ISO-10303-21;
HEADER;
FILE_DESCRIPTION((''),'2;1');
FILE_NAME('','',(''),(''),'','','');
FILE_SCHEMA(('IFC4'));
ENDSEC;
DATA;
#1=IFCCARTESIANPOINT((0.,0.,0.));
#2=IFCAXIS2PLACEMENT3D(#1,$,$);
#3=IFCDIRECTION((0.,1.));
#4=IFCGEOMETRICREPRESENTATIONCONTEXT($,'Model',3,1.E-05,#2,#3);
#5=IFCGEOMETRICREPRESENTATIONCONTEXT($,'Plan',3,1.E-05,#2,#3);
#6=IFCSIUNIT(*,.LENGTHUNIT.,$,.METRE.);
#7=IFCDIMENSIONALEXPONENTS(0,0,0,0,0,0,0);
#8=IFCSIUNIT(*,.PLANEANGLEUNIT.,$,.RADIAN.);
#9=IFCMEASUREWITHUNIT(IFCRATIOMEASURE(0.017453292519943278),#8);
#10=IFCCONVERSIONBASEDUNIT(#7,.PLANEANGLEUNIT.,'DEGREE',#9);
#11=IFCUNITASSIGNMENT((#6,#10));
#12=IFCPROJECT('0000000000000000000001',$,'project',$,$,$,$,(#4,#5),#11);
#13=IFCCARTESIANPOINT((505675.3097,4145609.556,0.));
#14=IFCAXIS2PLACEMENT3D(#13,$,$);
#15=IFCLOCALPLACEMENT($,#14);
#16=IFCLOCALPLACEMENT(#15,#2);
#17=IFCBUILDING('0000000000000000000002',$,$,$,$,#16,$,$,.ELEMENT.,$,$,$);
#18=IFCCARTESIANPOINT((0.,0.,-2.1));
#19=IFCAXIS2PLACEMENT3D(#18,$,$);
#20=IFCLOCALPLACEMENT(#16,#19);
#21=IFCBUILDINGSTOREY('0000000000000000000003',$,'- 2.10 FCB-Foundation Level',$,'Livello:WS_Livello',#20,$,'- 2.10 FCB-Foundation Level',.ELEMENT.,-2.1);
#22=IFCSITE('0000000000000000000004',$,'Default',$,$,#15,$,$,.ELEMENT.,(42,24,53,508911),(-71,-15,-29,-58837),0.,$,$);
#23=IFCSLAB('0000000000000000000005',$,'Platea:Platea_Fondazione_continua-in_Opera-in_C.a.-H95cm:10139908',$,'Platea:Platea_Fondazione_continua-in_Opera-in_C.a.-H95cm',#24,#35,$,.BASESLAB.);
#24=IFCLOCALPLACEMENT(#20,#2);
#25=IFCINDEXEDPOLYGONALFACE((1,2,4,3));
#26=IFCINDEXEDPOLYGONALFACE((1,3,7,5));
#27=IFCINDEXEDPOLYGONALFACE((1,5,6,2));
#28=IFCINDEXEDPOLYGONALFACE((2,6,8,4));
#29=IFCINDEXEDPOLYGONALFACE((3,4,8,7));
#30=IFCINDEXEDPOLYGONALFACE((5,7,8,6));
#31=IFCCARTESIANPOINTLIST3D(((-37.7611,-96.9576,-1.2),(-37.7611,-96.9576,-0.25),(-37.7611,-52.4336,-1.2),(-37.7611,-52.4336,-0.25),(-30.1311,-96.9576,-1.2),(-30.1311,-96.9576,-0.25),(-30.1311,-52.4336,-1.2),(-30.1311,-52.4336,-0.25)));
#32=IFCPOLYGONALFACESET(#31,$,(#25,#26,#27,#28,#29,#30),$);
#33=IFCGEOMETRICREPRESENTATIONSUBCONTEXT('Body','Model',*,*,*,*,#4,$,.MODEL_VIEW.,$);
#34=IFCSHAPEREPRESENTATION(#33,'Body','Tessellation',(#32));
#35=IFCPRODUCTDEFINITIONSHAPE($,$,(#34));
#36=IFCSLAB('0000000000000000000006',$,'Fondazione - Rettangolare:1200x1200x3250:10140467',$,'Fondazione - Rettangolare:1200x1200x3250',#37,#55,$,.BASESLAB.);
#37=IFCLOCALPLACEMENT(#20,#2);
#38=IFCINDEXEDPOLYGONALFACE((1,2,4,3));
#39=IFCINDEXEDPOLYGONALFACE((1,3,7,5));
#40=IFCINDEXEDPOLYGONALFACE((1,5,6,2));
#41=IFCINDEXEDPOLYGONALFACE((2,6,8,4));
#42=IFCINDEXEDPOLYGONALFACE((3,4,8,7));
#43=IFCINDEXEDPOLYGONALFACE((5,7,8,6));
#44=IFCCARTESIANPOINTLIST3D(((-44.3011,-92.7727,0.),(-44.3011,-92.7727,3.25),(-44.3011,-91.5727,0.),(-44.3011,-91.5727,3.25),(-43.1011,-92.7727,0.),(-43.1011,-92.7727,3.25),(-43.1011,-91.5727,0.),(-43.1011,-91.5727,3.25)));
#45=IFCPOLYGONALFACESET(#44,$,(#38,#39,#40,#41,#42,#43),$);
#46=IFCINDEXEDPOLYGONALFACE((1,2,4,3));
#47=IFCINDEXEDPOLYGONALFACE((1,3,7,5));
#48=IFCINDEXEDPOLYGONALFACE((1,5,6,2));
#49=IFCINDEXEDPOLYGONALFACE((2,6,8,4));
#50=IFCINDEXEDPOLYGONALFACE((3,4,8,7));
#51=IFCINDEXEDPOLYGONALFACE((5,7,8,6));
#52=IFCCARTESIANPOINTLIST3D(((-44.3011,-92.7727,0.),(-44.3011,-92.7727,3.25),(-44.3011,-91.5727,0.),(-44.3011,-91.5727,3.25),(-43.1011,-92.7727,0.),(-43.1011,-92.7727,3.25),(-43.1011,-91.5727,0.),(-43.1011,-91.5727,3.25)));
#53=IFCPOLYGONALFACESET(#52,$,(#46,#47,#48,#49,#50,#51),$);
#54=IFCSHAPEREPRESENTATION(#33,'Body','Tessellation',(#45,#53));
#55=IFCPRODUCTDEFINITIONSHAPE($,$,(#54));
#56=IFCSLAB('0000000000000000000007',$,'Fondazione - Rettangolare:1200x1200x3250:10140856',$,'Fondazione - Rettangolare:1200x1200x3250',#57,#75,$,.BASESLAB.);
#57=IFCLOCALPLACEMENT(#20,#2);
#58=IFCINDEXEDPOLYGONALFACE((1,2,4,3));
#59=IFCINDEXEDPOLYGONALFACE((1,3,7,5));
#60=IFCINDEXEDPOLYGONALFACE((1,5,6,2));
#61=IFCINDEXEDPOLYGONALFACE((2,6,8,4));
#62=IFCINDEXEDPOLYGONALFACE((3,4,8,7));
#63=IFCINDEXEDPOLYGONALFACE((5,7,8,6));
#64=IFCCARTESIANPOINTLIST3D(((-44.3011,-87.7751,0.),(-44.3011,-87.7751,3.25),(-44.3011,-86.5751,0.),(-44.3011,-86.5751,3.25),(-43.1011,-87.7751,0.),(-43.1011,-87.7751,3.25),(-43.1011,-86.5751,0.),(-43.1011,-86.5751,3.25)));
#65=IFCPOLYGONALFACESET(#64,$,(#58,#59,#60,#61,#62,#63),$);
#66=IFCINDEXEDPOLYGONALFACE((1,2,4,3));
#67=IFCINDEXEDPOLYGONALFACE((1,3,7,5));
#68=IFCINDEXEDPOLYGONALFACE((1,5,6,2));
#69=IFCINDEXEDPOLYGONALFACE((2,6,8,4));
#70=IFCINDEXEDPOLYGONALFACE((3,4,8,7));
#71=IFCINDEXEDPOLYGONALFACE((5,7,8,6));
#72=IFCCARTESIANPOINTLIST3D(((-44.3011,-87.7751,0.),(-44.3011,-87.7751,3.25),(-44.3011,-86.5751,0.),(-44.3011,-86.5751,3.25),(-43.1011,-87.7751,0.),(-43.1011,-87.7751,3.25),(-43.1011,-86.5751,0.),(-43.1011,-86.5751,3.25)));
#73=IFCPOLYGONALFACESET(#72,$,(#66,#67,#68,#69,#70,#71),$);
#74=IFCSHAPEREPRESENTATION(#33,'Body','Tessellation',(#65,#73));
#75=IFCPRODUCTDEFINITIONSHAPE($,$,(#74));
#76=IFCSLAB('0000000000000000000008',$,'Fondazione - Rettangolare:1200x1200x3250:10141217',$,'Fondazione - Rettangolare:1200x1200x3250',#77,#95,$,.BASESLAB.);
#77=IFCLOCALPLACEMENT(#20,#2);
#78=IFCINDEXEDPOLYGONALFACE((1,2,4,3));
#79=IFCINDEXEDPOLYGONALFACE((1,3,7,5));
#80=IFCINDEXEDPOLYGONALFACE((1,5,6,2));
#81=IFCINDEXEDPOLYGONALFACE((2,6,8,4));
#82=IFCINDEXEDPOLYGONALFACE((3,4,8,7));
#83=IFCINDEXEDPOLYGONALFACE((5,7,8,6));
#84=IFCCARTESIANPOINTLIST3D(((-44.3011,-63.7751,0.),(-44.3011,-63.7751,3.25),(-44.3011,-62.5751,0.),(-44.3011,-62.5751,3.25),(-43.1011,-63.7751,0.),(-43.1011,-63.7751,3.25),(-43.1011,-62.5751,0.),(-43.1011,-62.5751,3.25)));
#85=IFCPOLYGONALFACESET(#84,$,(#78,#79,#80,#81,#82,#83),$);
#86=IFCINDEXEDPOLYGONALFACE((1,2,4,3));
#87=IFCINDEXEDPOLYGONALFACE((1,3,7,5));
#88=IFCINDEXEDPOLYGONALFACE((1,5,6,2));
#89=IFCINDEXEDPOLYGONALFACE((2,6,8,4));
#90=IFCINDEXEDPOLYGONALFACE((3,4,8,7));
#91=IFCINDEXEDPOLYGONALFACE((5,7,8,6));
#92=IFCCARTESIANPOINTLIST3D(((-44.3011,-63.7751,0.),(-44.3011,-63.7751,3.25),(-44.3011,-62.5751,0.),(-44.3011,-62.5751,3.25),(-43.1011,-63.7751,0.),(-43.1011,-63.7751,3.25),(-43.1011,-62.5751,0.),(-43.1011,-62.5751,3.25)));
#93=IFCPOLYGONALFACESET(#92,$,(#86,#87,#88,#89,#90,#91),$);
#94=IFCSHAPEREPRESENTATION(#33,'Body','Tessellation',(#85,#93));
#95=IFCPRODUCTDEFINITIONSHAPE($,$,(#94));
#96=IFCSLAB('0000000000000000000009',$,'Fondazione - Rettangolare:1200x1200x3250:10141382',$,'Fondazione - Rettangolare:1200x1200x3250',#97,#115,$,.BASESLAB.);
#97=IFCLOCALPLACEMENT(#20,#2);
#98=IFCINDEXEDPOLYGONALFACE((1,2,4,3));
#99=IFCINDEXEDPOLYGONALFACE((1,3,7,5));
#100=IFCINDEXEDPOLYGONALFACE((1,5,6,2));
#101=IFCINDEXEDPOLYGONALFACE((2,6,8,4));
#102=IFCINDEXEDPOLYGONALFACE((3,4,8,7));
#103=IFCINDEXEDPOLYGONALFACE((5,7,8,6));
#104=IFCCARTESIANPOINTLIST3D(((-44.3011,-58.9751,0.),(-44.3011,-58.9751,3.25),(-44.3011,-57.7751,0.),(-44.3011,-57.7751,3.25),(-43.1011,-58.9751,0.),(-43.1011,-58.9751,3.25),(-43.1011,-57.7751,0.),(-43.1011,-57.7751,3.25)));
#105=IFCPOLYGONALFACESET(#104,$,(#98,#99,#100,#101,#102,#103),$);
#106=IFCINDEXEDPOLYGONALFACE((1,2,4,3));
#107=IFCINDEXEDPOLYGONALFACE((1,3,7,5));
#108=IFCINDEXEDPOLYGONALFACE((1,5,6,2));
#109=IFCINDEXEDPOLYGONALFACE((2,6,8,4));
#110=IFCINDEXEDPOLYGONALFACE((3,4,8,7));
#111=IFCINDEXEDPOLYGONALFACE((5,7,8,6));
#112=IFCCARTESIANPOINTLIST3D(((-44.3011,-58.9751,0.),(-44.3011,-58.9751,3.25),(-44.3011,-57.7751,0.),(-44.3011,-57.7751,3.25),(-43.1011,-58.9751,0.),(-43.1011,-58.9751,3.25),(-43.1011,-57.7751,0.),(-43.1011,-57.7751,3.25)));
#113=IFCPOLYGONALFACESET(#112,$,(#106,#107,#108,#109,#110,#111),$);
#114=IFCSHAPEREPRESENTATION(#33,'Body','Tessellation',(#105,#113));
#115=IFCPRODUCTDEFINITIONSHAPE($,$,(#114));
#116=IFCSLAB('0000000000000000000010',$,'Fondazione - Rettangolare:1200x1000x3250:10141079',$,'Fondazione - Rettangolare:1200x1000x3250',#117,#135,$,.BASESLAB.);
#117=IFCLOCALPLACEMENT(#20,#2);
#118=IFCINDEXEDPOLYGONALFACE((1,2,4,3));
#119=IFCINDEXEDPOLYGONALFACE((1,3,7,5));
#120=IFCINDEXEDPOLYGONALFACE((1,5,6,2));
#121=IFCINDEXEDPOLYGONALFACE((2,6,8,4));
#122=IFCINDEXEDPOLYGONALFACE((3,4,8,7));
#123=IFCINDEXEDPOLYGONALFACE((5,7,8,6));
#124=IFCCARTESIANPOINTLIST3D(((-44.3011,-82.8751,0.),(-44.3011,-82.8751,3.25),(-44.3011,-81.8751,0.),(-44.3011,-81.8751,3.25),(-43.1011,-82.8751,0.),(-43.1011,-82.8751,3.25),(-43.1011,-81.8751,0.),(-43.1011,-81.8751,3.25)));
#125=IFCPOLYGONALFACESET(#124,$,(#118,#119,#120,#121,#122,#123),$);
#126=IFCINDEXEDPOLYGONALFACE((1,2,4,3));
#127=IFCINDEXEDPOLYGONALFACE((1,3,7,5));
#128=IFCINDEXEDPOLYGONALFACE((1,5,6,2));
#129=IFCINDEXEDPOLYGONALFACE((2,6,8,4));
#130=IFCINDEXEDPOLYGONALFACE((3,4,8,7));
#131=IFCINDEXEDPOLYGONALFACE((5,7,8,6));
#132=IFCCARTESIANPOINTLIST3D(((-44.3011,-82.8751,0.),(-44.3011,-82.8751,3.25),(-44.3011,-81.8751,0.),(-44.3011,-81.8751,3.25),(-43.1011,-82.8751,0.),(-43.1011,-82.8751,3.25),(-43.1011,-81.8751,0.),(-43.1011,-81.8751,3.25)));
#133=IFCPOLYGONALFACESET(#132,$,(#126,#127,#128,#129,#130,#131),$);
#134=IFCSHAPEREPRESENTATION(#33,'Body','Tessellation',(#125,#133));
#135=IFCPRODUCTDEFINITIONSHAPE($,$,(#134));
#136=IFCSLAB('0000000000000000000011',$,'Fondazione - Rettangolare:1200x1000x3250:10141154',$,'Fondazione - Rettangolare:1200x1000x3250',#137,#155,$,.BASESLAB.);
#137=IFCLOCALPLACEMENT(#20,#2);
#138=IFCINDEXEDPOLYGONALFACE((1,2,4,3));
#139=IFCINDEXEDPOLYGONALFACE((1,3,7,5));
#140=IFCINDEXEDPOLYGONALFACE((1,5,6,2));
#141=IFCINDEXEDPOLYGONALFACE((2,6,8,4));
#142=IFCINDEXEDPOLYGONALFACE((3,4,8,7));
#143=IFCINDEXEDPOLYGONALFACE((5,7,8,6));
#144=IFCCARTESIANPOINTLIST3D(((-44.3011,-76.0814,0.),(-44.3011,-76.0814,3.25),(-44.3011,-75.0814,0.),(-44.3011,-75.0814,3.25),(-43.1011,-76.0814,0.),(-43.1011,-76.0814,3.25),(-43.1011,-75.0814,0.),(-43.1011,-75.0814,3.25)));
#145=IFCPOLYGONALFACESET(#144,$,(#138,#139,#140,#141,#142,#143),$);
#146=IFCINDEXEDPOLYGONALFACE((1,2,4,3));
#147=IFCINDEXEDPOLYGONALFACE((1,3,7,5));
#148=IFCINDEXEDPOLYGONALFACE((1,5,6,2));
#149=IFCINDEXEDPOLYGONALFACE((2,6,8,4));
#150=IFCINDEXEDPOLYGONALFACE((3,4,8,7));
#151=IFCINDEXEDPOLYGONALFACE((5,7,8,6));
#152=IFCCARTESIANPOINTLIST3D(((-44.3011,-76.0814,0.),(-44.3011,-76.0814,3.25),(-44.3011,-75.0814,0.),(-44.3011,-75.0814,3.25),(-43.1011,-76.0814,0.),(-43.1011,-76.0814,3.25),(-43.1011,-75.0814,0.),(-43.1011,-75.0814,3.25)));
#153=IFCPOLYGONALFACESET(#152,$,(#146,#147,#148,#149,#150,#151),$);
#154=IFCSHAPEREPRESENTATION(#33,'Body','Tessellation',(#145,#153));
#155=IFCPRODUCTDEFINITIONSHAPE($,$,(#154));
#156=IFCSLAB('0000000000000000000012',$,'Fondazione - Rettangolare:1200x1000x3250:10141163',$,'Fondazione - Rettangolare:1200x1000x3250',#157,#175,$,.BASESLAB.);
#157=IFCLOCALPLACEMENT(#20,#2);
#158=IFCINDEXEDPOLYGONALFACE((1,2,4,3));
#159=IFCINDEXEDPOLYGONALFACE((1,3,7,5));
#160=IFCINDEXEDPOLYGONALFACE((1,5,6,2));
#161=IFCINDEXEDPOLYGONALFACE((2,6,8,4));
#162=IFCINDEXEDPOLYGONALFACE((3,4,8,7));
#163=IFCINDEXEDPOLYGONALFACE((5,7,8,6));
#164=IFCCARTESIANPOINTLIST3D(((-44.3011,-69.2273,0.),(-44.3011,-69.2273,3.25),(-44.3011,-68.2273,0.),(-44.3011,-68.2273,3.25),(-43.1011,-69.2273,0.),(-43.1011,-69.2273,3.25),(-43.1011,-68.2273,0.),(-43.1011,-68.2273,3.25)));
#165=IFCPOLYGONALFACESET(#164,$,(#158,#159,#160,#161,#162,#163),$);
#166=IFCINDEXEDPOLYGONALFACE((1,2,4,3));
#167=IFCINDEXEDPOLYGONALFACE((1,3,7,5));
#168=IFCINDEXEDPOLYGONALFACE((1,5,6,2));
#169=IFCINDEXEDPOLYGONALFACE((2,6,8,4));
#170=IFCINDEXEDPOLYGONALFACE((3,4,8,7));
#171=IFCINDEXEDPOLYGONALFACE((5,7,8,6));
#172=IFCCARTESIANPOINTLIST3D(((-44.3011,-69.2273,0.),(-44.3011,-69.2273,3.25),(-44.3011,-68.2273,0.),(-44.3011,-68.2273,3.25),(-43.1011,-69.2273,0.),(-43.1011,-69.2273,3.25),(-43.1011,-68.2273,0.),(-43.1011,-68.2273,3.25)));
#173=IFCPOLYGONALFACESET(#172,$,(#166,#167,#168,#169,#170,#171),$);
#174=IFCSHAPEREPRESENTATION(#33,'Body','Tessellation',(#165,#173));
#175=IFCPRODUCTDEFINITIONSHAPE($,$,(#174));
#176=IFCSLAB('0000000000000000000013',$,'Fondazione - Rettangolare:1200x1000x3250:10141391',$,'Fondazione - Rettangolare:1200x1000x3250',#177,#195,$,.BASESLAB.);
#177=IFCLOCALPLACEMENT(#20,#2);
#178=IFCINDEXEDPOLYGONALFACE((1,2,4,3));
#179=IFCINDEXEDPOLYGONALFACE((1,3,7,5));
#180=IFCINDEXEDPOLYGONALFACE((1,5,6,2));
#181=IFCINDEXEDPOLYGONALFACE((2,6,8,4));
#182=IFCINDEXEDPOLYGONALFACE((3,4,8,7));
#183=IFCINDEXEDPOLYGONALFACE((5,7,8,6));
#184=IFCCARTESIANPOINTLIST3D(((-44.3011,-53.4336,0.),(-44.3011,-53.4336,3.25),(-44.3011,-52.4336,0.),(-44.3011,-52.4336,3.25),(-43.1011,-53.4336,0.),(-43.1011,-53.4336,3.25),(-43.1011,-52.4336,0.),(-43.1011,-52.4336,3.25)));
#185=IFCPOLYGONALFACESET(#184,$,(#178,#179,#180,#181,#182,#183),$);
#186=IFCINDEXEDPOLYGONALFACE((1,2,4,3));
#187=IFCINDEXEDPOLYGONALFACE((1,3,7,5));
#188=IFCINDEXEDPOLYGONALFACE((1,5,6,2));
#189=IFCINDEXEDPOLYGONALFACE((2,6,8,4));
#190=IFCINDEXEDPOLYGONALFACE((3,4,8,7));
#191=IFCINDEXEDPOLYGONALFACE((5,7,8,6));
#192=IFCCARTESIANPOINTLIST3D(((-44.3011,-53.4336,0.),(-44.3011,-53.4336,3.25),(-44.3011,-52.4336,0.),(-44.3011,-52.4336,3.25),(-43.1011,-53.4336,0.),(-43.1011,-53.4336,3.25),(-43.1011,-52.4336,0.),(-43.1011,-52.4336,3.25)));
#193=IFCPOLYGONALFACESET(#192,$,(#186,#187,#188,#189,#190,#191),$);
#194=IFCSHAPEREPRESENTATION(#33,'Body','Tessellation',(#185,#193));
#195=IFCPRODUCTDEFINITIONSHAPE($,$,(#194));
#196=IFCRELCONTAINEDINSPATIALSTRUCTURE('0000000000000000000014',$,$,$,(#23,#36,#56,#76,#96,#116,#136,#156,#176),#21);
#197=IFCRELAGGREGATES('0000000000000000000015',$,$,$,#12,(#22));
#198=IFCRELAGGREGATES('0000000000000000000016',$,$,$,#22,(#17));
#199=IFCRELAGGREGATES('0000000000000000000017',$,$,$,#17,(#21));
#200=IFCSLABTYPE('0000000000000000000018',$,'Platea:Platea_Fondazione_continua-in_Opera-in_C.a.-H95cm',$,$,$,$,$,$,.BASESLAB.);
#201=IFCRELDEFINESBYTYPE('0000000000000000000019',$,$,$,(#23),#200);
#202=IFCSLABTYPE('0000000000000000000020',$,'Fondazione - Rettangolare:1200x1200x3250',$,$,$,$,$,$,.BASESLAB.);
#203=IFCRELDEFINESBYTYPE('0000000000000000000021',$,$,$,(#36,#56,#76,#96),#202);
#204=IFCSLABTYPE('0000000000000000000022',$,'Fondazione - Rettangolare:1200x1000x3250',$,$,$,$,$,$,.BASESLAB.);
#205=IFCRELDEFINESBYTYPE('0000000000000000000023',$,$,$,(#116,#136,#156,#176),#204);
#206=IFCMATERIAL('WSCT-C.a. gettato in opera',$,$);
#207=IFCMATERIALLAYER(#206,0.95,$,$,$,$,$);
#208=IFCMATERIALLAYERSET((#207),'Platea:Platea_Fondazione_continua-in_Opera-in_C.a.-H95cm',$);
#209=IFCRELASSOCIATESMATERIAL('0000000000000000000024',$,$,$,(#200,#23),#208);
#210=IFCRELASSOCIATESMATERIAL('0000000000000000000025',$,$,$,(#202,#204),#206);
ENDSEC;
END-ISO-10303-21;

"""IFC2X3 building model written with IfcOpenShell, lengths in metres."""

from ifc_helpers import new_model, entity, si_unit, converted_unit, direction, frame, frame_2d, origin, place, context, subcontext, project, spatial, rectangle, extrude, material, layer, layer_set, layer_usage, type_object, element, save


model = new_model("IFC2X3")

# Units and contexts
model_context = context("Model", 3, precision=1e-05, world=origin(), true_north=direction((0.0, 1.0)))
plan_context = context("Plan", 3, precision=1e-05, world=origin(), true_north=direction((0.0, 1.0)))
body_context = subcontext(model_context, "Body", "Model", "MODEL_VIEW")
ifc_project = project(units=[si_unit("LENGTHUNIT", "METRE"), converted_unit("PLANEANGLEUNIT", "DEGREE", entity("IfcRatioMeasure", 0.017453292519943278), si_unit("PLANEANGLEUNIT", "RADIAN"), dimensions=[0, 0, 0, 0, 0, 0, 0])], contexts=[model_context, plan_context])

# Site, building, storey
site_placement = place(None, frame((505675.3097, 4145609.556, 0.0)))
site = spatial("IfcSite", under=ifc_project, at=site_placement, Name="Default", CompositionType="ELEMENT", RefLatitude=(42, 24, 53, 508911), RefLongitude=(-71, -15, -29, -58837), RefElevation=0.0)
building_placement = place(site_placement, origin())
building = spatial("IfcBuilding", under=site, at=building_placement, CompositionType="ELEMENT")
storey_placement = place(building_placement, frame((0.0, 0.0, -2.1)))
storey = spatial("IfcBuildingStorey", under=building, at=storey_placement, Name="- 2.10 FCB-Foundation Level", ObjectType="Livello:WS_Livello", LongName="- 2.10 FCB-Foundation Level", CompositionType="ELEMENT", Elevation=-2.1)

# Slabs
ifc_material = material(Name="WSCT-C.a. gettato in opera")
ifc_layer_1 = layer(ifc_material, 0.95)
ifc_layer_set_1 = layer_set([ifc_layer_1], Name="Platea:Platea_Fondazione_continua-in_Opera-in_C.a.-H95cm")
ifc_layer_usage_1 = layer_usage(ifc_layer_set_1, "AXIS3", "POSITIVE", 0.0)
slab_type_1 = type_object("IfcSlabType", Name="Platea:Platea_Fondazione_continua-in_Opera-in_C.a.-H95cm", PredefinedType="BASESLAB", material=ifc_layer_set_1)
slab_1_placement = place(storey_placement, origin())
element("IfcSlab", 1, at=slab_1_placement, inside=storey, type_object=slab_type_1, material=ifc_layer_usage_1, Name="Platea:Platea_Fondazione_continua-in_Opera-in_C.a.-H95cm:10139908", ObjectType="Platea:Platea_Fondazione_continua-in_Opera-in_C.a.-H95cm", PredefinedType="BASESLAB", context=body_context, shape_type="SweptSolid", body=[
    extrude(rectangle(XDim=44.524, YDim=7.63, at=frame_2d((0.0, 0.0), x_axis=(1.0, 0.0))), frame((-33.9461, -74.6956, -0.25), z_axis=(0.0, 0.0, -1.0), x_axis=(0.0, 1.0, 0.0)), (0.0, 0.0, 1.0), 0.95),
])
slab_type_2 = type_object("IfcSlabType", Name="Fondazione - Rettangolare:1200x1200x3250", PredefinedType="BASESLAB", material=ifc_material)
slab_2_placement = place(storey_placement, origin())
element("IfcSlab", 2, at=slab_2_placement, inside=storey, type_object=slab_type_2, Name="Fondazione - Rettangolare:1200x1200x3250:10140467", ObjectType="Fondazione - Rettangolare:1200x1200x3250", PredefinedType="BASESLAB", context=body_context, shape_type="SweptSolid", body=[
    extrude(rectangle(XDim=1.2, YDim=1.2, at=frame_2d((0.0, 0.0), x_axis=(1.0, 0.0))), frame((-43.7011, -92.1727, 0.0), z_axis=(0.0, 0.0, 1.0), x_axis=(-1.0, 0.0, 0.0)), (0.0, 0.0, 1.0), 3.25),
    extrude(rectangle(XDim=1.2, YDim=1.2, at=frame_2d((0.0, 0.0), x_axis=(1.0, 0.0))), frame((-43.7011, -92.1727, 0.0), z_axis=(0.0, 0.0, 1.0), x_axis=(-1.0, 0.0, 0.0)), (0.0, 0.0, 1.0), 3.25),
])
slab_3_placement = place(storey_placement, origin())
element("IfcSlab", 3, at=slab_3_placement, inside=storey, type_object=slab_type_2, Name="Fondazione - Rettangolare:1200x1200x3250:10140856", ObjectType="Fondazione - Rettangolare:1200x1200x3250", PredefinedType="BASESLAB", context=body_context, shape_type="SweptSolid", body=[
    extrude(rectangle(XDim=1.2, YDim=1.2, at=frame_2d((0.0, 0.0), x_axis=(1.0, 0.0))), frame((-43.7011, -87.1751, 0.0), z_axis=(0.0, 0.0, 1.0), x_axis=(-1.0, 0.0, 0.0)), (0.0, 0.0, 1.0), 3.25),
    extrude(rectangle(XDim=1.2, YDim=1.2, at=frame_2d((0.0, 0.0), x_axis=(1.0, 0.0))), frame((-43.7011, -87.1751, 0.0), z_axis=(0.0, 0.0, 1.0), x_axis=(-1.0, 0.0, 0.0)), (0.0, 0.0, 1.0), 3.25),
])
slab_4_placement = place(storey_placement, origin())
element("IfcSlab", 4, at=slab_4_placement, inside=storey, type_object=slab_type_2, Name="Fondazione - Rettangolare:1200x1200x3250:10141217", ObjectType="Fondazione - Rettangolare:1200x1200x3250", PredefinedType="BASESLAB", context=body_context, shape_type="SweptSolid", body=[
    extrude(rectangle(XDim=1.2, YDim=1.2, at=frame_2d((0.0, 0.0), x_axis=(1.0, 0.0))), frame((-43.7011, -63.1751, 0.0), z_axis=(0.0, 0.0, 1.0), x_axis=(-1.0, 0.0, 0.0)), (0.0, 0.0, 1.0), 3.25),
    extrude(rectangle(XDim=1.2, YDim=1.2, at=frame_2d((0.0, 0.0), x_axis=(1.0, 0.0))), frame((-43.7011, -63.1751, 0.0), z_axis=(0.0, 0.0, 1.0), x_axis=(-1.0, 0.0, 0.0)), (0.0, 0.0, 1.0), 3.25),
])
slab_5_placement = place(storey_placement, origin())
element("IfcSlab", 5, at=slab_5_placement, inside=storey, type_object=slab_type_2, Name="Fondazione - Rettangolare:1200x1200x3250:10141382", ObjectType="Fondazione - Rettangolare:1200x1200x3250", PredefinedType="BASESLAB", context=body_context, shape_type="SweptSolid", body=[
    extrude(rectangle(XDim=1.2, YDim=1.2, at=frame_2d((0.0, 0.0), x_axis=(1.0, 0.0))), frame((-43.7011, -58.3751, 0.0), z_axis=(0.0, 0.0, 1.0), x_axis=(-1.0, 0.0, 0.0)), (0.0, 0.0, 1.0), 3.25),
    extrude(rectangle(XDim=1.2, YDim=1.2, at=frame_2d((0.0, 0.0), x_axis=(1.0, 0.0))), frame((-43.7011, -58.3751, 0.0), z_axis=(0.0, 0.0, 1.0), x_axis=(-1.0, 0.0, 0.0)), (0.0, 0.0, 1.0), 3.25),
])
slab_type_3 = type_object("IfcSlabType", Name="Fondazione - Rettangolare:1200x1000x3250", PredefinedType="BASESLAB", material=ifc_material)
slab_6_placement = place(storey_placement, origin())
element("IfcSlab", 6, at=slab_6_placement, inside=storey, type_object=slab_type_3, Name="Fondazione - Rettangolare:1200x1000x3250:10141079", ObjectType="Fondazione - Rettangolare:1200x1000x3250", PredefinedType="BASESLAB", context=body_context, shape_type="SweptSolid", body=[
    extrude(rectangle(XDim=1.2, YDim=1.0, at=frame_2d((0.0, 0.0), x_axis=(1.0, 0.0))), frame((-43.7011, -82.3751, 0.0), z_axis=(0.0, 0.0, 1.0), x_axis=(-1.0, 0.0, 0.0)), (0.0, 0.0, 1.0), 3.25),
    extrude(rectangle(XDim=1.2, YDim=1.0, at=frame_2d((0.0, 0.0), x_axis=(1.0, 0.0))), frame((-43.7011, -82.3751, 0.0), z_axis=(0.0, 0.0, 1.0), x_axis=(-1.0, 0.0, 0.0)), (0.0, 0.0, 1.0), 3.25),
])
slab_7_placement = place(storey_placement, origin())
element("IfcSlab", 7, at=slab_7_placement, inside=storey, type_object=slab_type_3, Name="Fondazione - Rettangolare:1200x1000x3250:10141154", ObjectType="Fondazione - Rettangolare:1200x1000x3250", PredefinedType="BASESLAB", context=body_context, shape_type="SweptSolid", body=[
    extrude(rectangle(XDim=1.2, YDim=1.0, at=frame_2d((0.0, 0.0), x_axis=(1.0, 0.0))), frame((-43.7011, -75.5814, 0.0), z_axis=(0.0, 0.0, 1.0), x_axis=(-1.0, 0.0, 0.0)), (0.0, 0.0, 1.0), 3.25),
    extrude(rectangle(XDim=1.2, YDim=1.0, at=frame_2d((0.0, 0.0), x_axis=(1.0, 0.0))), frame((-43.7011, -75.5814, 0.0), z_axis=(0.0, 0.0, 1.0), x_axis=(-1.0, 0.0, 0.0)), (0.0, 0.0, 1.0), 3.25),
])
slab_8_placement = place(storey_placement, origin())
element("IfcSlab", 8, at=slab_8_placement, inside=storey, type_object=slab_type_3, Name="Fondazione - Rettangolare:1200x1000x3250:10141163", ObjectType="Fondazione - Rettangolare:1200x1000x3250", PredefinedType="BASESLAB", context=body_context, shape_type="SweptSolid", body=[
    extrude(rectangle(XDim=1.2, YDim=1.0, at=frame_2d((0.0, 0.0), x_axis=(1.0, 0.0))), frame((-43.7011, -68.7273, 0.0), z_axis=(0.0, 0.0, 1.0), x_axis=(-1.0, 0.0, 0.0)), (0.0, 0.0, 1.0), 3.25),
    extrude(rectangle(XDim=1.2, YDim=1.0, at=frame_2d((0.0, 0.0), x_axis=(1.0, 0.0))), frame((-43.7011, -68.7273, 0.0), z_axis=(0.0, 0.0, 1.0), x_axis=(-1.0, 0.0, 0.0)), (0.0, 0.0, 1.0), 3.25),
])
slab_9_placement = place(storey_placement, origin())
element("IfcSlab", 9, at=slab_9_placement, inside=storey, type_object=slab_type_3, Name="Fondazione - Rettangolare:1200x1000x3250:10141391", ObjectType="Fondazione - Rettangolare:1200x1000x3250", PredefinedType="BASESLAB", context=body_context, shape_type="SweptSolid", body=[
    extrude(rectangle(XDim=1.2, YDim=1.0, at=frame_2d((0.0, 0.0), x_axis=(1.0, 0.0))), frame((-43.7011, -52.9336, 0.0), z_axis=(0.0, 0.0, 1.0), x_axis=(-1.0, 0.0, 0.0)), (0.0, 0.0, 1.0), 3.25),
    extrude(rectangle(XDim=1.2, YDim=1.0, at=frame_2d((0.0, 0.0), x_axis=(1.0, 0.0))), frame((-43.7011, -52.9336, 0.0), z_axis=(0.0, 0.0, 1.0), x_axis=(-1.0, 0.0, 0.0)), (0.0, 0.0, 1.0), 3.25),
])

save(model, "model.ifc")
